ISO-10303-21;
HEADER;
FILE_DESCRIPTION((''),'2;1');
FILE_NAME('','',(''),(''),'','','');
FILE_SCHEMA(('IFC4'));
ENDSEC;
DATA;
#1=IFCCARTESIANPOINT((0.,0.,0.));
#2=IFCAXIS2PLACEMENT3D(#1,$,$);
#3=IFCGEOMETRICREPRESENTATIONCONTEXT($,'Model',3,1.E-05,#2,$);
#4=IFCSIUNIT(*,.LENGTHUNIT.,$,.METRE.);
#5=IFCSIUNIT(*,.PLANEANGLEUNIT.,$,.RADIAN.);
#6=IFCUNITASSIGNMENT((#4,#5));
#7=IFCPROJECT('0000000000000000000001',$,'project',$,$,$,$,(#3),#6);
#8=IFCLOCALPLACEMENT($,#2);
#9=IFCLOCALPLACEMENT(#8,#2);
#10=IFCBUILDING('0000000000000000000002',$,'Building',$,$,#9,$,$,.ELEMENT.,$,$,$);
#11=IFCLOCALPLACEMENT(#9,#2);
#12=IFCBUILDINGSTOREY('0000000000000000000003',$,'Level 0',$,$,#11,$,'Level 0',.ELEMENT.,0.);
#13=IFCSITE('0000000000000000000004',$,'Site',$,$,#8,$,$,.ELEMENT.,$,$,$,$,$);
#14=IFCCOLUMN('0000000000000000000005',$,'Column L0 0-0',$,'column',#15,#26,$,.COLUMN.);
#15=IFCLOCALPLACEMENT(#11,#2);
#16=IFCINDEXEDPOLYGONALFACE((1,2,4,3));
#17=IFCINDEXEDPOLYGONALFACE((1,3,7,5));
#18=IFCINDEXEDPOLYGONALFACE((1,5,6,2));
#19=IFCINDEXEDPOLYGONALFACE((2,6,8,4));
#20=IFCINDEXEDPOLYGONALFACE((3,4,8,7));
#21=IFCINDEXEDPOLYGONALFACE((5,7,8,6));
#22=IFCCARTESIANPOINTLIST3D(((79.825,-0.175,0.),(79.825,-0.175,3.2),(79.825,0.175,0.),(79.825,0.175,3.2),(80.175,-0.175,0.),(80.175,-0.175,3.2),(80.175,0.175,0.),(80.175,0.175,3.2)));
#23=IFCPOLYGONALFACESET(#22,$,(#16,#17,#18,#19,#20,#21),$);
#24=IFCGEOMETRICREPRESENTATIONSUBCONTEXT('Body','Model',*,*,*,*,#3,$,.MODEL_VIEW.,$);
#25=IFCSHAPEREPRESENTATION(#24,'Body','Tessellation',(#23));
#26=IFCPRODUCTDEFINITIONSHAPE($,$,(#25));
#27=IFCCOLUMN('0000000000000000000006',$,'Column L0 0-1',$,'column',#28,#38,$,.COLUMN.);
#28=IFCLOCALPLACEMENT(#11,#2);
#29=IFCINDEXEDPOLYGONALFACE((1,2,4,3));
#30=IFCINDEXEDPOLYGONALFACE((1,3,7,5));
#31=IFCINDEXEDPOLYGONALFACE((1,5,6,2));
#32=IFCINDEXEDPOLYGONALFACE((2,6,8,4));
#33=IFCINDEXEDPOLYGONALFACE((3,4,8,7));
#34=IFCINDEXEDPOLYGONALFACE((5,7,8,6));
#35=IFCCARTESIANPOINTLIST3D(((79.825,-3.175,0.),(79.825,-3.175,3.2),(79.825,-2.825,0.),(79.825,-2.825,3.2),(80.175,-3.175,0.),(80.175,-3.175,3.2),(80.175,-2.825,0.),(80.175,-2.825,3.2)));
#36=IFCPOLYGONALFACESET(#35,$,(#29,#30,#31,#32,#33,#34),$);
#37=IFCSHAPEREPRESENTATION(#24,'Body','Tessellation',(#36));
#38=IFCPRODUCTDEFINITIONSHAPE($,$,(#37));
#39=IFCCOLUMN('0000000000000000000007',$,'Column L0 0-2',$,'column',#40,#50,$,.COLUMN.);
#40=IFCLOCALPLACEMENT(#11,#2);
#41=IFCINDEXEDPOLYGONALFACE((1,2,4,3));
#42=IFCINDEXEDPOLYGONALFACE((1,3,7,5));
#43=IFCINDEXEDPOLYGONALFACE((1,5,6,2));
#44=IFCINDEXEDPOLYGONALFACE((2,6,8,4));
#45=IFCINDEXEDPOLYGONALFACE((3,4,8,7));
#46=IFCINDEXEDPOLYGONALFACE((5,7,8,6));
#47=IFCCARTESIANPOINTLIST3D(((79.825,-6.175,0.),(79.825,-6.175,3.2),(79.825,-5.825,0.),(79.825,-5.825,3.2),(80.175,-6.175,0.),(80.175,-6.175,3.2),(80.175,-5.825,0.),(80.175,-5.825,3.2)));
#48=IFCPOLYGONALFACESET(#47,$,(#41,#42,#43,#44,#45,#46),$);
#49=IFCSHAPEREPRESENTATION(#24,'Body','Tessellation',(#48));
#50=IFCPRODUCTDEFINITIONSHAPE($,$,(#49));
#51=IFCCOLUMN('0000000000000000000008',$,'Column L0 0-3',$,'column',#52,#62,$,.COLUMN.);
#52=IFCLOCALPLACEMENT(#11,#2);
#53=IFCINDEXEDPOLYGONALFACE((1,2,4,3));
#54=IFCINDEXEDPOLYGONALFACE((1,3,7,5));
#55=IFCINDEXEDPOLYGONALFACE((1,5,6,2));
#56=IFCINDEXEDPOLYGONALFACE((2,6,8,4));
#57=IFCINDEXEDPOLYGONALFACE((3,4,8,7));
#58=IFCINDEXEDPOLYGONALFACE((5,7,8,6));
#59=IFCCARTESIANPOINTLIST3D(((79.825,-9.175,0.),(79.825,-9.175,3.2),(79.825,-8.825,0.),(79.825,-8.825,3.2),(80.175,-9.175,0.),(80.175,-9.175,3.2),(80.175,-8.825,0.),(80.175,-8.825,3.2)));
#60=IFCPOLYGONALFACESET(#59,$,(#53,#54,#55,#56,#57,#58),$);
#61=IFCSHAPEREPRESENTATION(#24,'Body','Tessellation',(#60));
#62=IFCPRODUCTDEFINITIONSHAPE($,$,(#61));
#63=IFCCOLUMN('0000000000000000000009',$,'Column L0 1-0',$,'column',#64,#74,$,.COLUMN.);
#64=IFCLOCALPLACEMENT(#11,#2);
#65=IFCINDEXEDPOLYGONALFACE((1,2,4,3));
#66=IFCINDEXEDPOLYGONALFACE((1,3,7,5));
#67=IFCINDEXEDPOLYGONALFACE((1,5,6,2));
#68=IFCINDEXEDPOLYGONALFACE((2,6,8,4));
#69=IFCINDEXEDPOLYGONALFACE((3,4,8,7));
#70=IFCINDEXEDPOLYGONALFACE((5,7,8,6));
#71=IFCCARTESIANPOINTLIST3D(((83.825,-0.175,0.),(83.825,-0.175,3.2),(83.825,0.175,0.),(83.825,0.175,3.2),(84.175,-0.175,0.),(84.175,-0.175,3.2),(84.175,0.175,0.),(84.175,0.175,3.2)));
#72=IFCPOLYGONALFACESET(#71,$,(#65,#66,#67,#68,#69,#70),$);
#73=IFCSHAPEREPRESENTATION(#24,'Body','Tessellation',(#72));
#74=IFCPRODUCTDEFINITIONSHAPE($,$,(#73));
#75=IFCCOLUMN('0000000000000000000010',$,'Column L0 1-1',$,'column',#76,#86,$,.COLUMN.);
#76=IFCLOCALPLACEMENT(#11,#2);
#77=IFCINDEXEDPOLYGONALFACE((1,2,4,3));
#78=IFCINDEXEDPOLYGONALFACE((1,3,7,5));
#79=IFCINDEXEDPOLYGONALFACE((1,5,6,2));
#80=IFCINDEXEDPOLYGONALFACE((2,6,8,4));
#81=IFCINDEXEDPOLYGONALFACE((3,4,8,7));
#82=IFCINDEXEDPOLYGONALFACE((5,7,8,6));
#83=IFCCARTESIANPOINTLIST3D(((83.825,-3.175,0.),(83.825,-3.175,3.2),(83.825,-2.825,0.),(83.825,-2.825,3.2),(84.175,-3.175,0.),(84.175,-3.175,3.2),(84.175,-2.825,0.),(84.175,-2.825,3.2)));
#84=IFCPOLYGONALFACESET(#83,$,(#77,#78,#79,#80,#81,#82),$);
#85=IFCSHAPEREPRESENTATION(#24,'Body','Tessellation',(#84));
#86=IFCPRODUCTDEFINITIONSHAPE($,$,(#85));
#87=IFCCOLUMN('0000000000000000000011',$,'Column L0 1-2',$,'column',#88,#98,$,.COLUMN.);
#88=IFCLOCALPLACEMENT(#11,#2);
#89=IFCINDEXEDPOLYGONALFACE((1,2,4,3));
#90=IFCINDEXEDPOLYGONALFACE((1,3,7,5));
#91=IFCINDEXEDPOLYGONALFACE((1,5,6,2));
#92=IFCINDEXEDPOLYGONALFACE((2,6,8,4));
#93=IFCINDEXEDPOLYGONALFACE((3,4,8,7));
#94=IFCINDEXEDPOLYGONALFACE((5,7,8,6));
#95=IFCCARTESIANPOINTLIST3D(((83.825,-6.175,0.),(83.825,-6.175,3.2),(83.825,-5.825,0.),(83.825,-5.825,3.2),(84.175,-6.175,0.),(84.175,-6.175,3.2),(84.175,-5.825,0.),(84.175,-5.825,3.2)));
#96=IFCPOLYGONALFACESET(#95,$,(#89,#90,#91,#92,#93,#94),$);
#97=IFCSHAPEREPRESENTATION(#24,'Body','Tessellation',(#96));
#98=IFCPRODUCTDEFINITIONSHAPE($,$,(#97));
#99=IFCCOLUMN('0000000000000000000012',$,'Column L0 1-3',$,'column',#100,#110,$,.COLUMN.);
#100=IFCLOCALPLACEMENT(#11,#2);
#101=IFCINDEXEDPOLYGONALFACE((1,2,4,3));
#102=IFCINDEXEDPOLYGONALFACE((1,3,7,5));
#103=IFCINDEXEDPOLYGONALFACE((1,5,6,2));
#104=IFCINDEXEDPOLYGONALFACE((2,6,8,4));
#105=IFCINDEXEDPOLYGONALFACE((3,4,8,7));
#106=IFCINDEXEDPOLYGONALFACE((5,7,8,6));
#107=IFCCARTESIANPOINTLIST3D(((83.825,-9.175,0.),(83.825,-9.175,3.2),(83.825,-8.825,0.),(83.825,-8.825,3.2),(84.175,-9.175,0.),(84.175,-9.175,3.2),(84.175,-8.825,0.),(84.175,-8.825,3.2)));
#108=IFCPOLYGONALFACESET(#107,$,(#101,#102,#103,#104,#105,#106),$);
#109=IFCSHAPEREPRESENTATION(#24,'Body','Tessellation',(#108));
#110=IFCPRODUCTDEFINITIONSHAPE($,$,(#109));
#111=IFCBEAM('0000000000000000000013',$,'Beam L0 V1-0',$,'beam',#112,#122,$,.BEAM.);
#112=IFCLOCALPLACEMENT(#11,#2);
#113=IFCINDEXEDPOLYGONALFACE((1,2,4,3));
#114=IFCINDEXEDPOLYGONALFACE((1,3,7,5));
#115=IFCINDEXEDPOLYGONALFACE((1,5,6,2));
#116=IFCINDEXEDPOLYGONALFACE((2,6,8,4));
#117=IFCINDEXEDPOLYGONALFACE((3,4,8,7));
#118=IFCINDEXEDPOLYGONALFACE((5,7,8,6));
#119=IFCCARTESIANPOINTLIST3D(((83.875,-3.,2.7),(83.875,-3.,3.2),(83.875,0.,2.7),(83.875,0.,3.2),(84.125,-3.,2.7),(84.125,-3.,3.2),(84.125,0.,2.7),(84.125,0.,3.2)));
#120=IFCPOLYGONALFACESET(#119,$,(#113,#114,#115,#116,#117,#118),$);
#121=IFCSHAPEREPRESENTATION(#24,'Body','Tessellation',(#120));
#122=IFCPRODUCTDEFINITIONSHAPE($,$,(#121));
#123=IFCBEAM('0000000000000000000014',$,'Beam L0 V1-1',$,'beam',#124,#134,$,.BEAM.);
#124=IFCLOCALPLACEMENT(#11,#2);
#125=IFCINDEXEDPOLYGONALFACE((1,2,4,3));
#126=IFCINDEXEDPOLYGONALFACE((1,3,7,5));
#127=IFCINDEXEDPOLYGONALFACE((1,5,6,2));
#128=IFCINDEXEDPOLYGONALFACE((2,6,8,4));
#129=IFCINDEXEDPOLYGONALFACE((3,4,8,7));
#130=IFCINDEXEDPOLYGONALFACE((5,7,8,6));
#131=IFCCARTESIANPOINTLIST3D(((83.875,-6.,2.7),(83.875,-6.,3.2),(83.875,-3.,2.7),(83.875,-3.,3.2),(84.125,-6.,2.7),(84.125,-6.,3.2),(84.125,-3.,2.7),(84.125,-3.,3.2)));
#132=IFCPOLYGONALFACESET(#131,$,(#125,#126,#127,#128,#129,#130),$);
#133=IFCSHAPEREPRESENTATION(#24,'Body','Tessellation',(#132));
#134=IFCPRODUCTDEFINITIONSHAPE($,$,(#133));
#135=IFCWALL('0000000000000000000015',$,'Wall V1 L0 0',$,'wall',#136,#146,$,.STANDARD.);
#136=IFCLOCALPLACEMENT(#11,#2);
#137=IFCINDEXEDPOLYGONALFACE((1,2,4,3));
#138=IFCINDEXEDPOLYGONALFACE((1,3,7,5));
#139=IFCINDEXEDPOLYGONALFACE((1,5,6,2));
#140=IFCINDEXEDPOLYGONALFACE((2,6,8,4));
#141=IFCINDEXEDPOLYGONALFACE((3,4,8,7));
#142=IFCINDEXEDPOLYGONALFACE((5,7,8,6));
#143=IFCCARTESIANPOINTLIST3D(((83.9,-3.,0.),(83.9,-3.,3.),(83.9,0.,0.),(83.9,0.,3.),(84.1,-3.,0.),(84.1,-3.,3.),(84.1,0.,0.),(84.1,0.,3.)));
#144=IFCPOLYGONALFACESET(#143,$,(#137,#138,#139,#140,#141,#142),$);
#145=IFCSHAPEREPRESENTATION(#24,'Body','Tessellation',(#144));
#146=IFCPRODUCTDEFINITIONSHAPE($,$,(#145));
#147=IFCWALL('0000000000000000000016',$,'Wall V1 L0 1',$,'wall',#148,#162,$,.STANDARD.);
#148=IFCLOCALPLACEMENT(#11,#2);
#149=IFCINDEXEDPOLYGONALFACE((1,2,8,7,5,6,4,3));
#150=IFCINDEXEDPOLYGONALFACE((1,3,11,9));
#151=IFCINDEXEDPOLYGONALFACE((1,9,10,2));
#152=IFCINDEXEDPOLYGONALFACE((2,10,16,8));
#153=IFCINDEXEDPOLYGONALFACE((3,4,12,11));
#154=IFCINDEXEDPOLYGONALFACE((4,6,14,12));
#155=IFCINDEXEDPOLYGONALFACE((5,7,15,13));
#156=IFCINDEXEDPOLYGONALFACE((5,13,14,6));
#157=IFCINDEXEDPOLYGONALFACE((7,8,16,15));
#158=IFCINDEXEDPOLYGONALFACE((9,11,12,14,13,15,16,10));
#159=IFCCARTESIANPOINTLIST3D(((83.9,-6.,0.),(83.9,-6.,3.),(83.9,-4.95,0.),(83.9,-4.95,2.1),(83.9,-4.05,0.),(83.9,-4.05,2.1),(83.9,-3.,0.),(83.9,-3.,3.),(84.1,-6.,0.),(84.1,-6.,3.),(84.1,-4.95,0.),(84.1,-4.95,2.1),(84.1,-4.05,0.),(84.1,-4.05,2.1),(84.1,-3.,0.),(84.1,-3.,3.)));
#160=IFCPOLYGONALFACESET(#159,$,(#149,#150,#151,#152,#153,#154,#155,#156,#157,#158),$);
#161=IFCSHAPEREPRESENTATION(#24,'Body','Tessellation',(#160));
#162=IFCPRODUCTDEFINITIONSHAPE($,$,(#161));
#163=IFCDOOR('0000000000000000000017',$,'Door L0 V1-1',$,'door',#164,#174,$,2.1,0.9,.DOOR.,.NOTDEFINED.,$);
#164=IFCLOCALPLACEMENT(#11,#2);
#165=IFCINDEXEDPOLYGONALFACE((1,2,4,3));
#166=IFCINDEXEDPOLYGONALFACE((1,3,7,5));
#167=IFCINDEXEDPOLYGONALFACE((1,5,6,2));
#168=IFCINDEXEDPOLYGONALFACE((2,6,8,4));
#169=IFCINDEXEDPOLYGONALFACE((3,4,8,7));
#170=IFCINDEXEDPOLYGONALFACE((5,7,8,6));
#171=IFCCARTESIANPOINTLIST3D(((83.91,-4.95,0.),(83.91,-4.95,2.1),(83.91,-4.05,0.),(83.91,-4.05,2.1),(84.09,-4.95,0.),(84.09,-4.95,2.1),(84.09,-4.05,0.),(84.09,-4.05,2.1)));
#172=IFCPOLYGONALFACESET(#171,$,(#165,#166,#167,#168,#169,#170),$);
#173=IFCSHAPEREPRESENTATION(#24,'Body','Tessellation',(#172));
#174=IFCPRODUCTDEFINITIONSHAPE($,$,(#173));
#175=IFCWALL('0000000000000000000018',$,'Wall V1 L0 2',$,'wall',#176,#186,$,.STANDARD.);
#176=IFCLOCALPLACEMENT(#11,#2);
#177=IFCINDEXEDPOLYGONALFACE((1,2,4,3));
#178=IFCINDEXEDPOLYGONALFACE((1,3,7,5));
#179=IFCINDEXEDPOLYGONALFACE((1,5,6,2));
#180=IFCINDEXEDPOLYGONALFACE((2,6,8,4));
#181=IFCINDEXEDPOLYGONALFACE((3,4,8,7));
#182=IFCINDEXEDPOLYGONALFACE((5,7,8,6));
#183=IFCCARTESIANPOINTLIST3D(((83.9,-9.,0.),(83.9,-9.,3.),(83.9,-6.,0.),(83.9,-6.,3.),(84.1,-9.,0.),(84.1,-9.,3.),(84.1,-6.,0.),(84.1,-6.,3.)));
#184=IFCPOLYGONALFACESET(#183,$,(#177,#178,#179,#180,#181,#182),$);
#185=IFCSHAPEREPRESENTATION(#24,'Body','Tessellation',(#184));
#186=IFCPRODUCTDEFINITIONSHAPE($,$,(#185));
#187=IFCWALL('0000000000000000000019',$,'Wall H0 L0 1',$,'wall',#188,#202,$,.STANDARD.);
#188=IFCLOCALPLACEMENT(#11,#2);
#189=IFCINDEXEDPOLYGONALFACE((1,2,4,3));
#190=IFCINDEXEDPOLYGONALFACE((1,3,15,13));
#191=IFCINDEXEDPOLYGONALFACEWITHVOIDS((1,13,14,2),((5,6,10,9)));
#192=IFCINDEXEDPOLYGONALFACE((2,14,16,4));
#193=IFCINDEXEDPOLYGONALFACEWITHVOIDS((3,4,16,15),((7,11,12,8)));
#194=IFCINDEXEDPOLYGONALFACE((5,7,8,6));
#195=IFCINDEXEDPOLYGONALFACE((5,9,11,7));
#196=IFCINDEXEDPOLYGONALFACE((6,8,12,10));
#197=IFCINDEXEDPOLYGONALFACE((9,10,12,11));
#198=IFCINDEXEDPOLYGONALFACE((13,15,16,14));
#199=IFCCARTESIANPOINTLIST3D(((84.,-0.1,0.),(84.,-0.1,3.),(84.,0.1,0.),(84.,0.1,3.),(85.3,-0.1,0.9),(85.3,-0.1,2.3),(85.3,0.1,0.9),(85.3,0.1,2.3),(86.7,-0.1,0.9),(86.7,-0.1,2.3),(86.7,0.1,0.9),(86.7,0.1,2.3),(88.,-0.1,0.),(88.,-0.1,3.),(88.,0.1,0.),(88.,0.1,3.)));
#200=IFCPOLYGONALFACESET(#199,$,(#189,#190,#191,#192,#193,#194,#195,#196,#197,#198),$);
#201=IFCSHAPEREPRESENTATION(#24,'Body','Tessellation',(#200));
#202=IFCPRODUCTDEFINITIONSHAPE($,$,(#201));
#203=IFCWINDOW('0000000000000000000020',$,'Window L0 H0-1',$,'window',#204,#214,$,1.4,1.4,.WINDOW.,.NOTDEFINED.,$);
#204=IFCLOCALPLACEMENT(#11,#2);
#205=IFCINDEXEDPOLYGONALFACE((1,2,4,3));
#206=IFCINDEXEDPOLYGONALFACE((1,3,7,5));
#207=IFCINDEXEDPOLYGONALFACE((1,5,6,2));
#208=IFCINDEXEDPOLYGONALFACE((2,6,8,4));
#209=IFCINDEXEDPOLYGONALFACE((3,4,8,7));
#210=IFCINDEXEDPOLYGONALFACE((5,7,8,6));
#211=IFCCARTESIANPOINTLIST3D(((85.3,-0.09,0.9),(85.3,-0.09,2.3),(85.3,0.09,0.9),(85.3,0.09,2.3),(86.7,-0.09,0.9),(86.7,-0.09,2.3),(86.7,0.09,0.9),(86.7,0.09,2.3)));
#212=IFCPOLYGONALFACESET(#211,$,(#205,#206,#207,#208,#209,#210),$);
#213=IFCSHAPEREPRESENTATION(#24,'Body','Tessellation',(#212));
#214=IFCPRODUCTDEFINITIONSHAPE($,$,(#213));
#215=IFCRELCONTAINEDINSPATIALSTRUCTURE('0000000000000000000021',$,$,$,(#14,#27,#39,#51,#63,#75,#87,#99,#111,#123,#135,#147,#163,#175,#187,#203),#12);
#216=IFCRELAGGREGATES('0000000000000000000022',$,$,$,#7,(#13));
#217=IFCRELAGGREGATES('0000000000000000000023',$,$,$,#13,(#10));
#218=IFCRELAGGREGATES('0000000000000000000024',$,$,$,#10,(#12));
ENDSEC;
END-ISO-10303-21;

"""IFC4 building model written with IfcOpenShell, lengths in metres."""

from ifc_helpers import new_model, si_unit, frame, frame_2d, origin, origin_2d, place, context, subcontext, project, spatial, rectangle, extrude, element, fill, save


model = new_model("IFC4")

# Units and contexts
model_context = context("Model", 3, precision=1e-05, world=origin())
body_context = subcontext(model_context, "Body", "Model", "MODEL_VIEW")
ifc_project = project(units=[si_unit("LENGTHUNIT", "METRE"), si_unit("PLANEANGLEUNIT", "RADIAN")], contexts=[model_context])

# Site, building, storey
site_placement = place(None, origin())
site = spatial("IfcSite", under=ifc_project, at=site_placement, Name="Site", CompositionType="ELEMENT")
building_placement = place(site_placement, origin())
building = spatial("IfcBuilding", under=site, at=building_placement, Name="Building", CompositionType="ELEMENT")
storey_placement = place(building_placement, origin())
storey = spatial("IfcBuildingStorey", under=building, at=storey_placement, Name="Level 0", LongName="Level 0", CompositionType="ELEMENT", Elevation=0.0)

# Columns
for number, where, name in (
    (1, (80.0, 0.0, 0.0), "Column L0 0-0"),
    (2, (80.0, -3.0, 0.0), "Column L0 0-1"),
    (3, (80.0, -6.0, 0.0), "Column L0 0-2"),
    (4, (80.0, -9.0, 0.0), "Column L0 0-3"),
    (5, (84.0, 0.0, 0.0), "Column L0 1-0"),
    (6, (84.0, -3.0, 0.0), "Column L0 1-1"),
    (7, (84.0, -6.0, 0.0), "Column L0 1-2"),
    (8, (84.0, -9.0, 0.0), "Column L0 1-3"),
):
    element("IfcColumn", number, at=place(storey_placement, frame(where)), inside=storey, Name=name, ObjectType="column", PredefinedType="COLUMN", context=body_context, shape_type="SweptSolid", body=[
        extrude(rectangle(XDim=0.35, YDim=0.35, at=origin_2d()), origin(), (0.0, 0.0, 1.0), 3.2),
    ])

# Beams
for number, where, z_axis, x_axis, name in (
    (9, (84.0, 0.0, 2.95), (0.0, -1.0, 0.0), (0.0, 0.0, 1.0), "Beam L0 V1-0"),
    (10, (84.0, -3.0, 2.95), (0.0, -1.0, 0.0), (0.0, 0.0, 1.0), "Beam L0 V1-1"),
):
    element("IfcBeam", number, at=place(storey_placement, frame(where, z_axis=z_axis, x_axis=x_axis)), inside=storey, Name=name, ObjectType="beam", PredefinedType="BEAM", context=body_context, shape_type="SweptSolid", body=[
        extrude(rectangle(XDim=0.5, YDim=0.25, at=origin_2d()), origin(), (0.0, 0.0, 1.0), 3.0),
    ])

# Wall
wall_1_placement = place(storey_placement, frame((84.0, 0.0, 0.0), z_axis=(0.0, 0.0, 1.0), x_axis=(0.0, -1.0, 0.0)))
element("IfcWall", 11, at=wall_1_placement, inside=storey, Name="Wall V1 L0 0", ObjectType="wall", PredefinedType="STANDARD", context=body_context, shape_type="SweptSolid", body=[
    extrude(rectangle(XDim=3.0, YDim=0.2, at=frame_2d((1.5, 0.0))), origin(), (0.0, 0.0, 1.0), 3.0),
])

# Wall, opening, door
wall_2_placement = place(storey_placement, frame((84.0, -3.0, 0.0), z_axis=(0.0, 0.0, 1.0), x_axis=(0.0, -1.0, 0.0)))
wall_2 = element("IfcWall", 12, at=wall_2_placement, inside=storey, Name="Wall V1 L0 1", ObjectType="wall", PredefinedType="STANDARD", context=body_context, shape_type="SweptSolid", body=[
    extrude(rectangle(XDim=3.0, YDim=0.2, at=frame_2d((1.5, 0.0))), origin(), (0.0, 0.0, 1.0), 3.0),
])
opening_1_placement = place(storey_placement, frame((84.0, -4.5, 0.0), z_axis=(0.0, 0.0, 1.0), x_axis=(0.0, -1.0, 0.0)))
opening_1 = element("IfcOpeningElement", 13, at=opening_1_placement, cuts=wall_2, ObjectType="Opening", PredefinedType="OPENING", context=body_context, shape_type="SweptSolid", body=[
    extrude(rectangle(XDim=0.9, YDim=0.22, at=origin_2d()), origin(), (0.0, 0.0, 1.0), 2.1),
])
door_placement = place(storey_placement, frame((84.0, -4.5, 0.0), z_axis=(0.0, 0.0, 1.0), x_axis=(0.0, -1.0, 0.0)))
door = element("IfcDoor", 14, at=door_placement, inside=storey, Name="Door L0 V1-1", ObjectType="door", OperationType="NOTDEFINED", OverallHeight=2.1, OverallWidth=0.9, PredefinedType="DOOR", context=body_context, shape_type="SweptSolid", body=[
    extrude(rectangle(XDim=0.9, YDim=0.18, at=origin_2d()), origin(), (0.0, 0.0, 1.0), 2.1),
])
fill(opening_1, door)

# Wall
wall_3_placement = place(storey_placement, frame((84.0, -6.0, 0.0), z_axis=(0.0, 0.0, 1.0), x_axis=(0.0, -1.0, 0.0)))
element("IfcWall", 15, at=wall_3_placement, inside=storey, Name="Wall V1 L0 2", ObjectType="wall", PredefinedType="STANDARD", context=body_context, shape_type="SweptSolid", body=[
    extrude(rectangle(XDim=3.0, YDim=0.2, at=frame_2d((1.5, 0.0))), origin(), (0.0, 0.0, 1.0), 3.0),
])

# Wall, opening, window
wall_4_placement = place(storey_placement, frame((84.0, 0.0, 0.0), z_axis=(0.0, 0.0, 1.0), x_axis=(1.0, 0.0, 0.0)))
wall_4 = element("IfcWall", 16, at=wall_4_placement, inside=storey, Name="Wall H0 L0 1", ObjectType="wall", PredefinedType="STANDARD", context=body_context, shape_type="SweptSolid", body=[
    extrude(rectangle(XDim=4.0, YDim=0.2, at=frame_2d((2.0, 0.0))), origin(), (0.0, 0.0, 1.0), 3.0),
])
opening_2_placement = place(storey_placement, frame((86.0, 0.0, 0.9), z_axis=(0.0, 0.0, 1.0), x_axis=(1.0, 0.0, 0.0)))
opening_2 = element("IfcOpeningElement", 17, at=opening_2_placement, cuts=wall_4, ObjectType="Opening", PredefinedType="OPENING", context=body_context, shape_type="SweptSolid", body=[
    extrude(rectangle(XDim=1.4, YDim=0.22, at=origin_2d()), origin(), (0.0, 0.0, 1.0), 1.4),
])
window_1_placement = place(storey_placement, frame((86.0, 0.0, 0.9), z_axis=(0.0, 0.0, 1.0), x_axis=(1.0, 0.0, 0.0)))
window_1 = element("IfcWindow", 18, at=window_1_placement, inside=storey, Name="Window L0 H0-1", ObjectType="window", OverallHeight=1.4, OverallWidth=1.4, PartitioningType="NOTDEFINED", PredefinedType="WINDOW", context=body_context, shape_type="SweptSolid", body=[
    extrude(rectangle(XDim=1.4, YDim=0.18, at=origin_2d()), origin(), (0.0, 0.0, 1.0), 1.4),
])
fill(opening_2, window_1)

save(model, "model.ifc")
